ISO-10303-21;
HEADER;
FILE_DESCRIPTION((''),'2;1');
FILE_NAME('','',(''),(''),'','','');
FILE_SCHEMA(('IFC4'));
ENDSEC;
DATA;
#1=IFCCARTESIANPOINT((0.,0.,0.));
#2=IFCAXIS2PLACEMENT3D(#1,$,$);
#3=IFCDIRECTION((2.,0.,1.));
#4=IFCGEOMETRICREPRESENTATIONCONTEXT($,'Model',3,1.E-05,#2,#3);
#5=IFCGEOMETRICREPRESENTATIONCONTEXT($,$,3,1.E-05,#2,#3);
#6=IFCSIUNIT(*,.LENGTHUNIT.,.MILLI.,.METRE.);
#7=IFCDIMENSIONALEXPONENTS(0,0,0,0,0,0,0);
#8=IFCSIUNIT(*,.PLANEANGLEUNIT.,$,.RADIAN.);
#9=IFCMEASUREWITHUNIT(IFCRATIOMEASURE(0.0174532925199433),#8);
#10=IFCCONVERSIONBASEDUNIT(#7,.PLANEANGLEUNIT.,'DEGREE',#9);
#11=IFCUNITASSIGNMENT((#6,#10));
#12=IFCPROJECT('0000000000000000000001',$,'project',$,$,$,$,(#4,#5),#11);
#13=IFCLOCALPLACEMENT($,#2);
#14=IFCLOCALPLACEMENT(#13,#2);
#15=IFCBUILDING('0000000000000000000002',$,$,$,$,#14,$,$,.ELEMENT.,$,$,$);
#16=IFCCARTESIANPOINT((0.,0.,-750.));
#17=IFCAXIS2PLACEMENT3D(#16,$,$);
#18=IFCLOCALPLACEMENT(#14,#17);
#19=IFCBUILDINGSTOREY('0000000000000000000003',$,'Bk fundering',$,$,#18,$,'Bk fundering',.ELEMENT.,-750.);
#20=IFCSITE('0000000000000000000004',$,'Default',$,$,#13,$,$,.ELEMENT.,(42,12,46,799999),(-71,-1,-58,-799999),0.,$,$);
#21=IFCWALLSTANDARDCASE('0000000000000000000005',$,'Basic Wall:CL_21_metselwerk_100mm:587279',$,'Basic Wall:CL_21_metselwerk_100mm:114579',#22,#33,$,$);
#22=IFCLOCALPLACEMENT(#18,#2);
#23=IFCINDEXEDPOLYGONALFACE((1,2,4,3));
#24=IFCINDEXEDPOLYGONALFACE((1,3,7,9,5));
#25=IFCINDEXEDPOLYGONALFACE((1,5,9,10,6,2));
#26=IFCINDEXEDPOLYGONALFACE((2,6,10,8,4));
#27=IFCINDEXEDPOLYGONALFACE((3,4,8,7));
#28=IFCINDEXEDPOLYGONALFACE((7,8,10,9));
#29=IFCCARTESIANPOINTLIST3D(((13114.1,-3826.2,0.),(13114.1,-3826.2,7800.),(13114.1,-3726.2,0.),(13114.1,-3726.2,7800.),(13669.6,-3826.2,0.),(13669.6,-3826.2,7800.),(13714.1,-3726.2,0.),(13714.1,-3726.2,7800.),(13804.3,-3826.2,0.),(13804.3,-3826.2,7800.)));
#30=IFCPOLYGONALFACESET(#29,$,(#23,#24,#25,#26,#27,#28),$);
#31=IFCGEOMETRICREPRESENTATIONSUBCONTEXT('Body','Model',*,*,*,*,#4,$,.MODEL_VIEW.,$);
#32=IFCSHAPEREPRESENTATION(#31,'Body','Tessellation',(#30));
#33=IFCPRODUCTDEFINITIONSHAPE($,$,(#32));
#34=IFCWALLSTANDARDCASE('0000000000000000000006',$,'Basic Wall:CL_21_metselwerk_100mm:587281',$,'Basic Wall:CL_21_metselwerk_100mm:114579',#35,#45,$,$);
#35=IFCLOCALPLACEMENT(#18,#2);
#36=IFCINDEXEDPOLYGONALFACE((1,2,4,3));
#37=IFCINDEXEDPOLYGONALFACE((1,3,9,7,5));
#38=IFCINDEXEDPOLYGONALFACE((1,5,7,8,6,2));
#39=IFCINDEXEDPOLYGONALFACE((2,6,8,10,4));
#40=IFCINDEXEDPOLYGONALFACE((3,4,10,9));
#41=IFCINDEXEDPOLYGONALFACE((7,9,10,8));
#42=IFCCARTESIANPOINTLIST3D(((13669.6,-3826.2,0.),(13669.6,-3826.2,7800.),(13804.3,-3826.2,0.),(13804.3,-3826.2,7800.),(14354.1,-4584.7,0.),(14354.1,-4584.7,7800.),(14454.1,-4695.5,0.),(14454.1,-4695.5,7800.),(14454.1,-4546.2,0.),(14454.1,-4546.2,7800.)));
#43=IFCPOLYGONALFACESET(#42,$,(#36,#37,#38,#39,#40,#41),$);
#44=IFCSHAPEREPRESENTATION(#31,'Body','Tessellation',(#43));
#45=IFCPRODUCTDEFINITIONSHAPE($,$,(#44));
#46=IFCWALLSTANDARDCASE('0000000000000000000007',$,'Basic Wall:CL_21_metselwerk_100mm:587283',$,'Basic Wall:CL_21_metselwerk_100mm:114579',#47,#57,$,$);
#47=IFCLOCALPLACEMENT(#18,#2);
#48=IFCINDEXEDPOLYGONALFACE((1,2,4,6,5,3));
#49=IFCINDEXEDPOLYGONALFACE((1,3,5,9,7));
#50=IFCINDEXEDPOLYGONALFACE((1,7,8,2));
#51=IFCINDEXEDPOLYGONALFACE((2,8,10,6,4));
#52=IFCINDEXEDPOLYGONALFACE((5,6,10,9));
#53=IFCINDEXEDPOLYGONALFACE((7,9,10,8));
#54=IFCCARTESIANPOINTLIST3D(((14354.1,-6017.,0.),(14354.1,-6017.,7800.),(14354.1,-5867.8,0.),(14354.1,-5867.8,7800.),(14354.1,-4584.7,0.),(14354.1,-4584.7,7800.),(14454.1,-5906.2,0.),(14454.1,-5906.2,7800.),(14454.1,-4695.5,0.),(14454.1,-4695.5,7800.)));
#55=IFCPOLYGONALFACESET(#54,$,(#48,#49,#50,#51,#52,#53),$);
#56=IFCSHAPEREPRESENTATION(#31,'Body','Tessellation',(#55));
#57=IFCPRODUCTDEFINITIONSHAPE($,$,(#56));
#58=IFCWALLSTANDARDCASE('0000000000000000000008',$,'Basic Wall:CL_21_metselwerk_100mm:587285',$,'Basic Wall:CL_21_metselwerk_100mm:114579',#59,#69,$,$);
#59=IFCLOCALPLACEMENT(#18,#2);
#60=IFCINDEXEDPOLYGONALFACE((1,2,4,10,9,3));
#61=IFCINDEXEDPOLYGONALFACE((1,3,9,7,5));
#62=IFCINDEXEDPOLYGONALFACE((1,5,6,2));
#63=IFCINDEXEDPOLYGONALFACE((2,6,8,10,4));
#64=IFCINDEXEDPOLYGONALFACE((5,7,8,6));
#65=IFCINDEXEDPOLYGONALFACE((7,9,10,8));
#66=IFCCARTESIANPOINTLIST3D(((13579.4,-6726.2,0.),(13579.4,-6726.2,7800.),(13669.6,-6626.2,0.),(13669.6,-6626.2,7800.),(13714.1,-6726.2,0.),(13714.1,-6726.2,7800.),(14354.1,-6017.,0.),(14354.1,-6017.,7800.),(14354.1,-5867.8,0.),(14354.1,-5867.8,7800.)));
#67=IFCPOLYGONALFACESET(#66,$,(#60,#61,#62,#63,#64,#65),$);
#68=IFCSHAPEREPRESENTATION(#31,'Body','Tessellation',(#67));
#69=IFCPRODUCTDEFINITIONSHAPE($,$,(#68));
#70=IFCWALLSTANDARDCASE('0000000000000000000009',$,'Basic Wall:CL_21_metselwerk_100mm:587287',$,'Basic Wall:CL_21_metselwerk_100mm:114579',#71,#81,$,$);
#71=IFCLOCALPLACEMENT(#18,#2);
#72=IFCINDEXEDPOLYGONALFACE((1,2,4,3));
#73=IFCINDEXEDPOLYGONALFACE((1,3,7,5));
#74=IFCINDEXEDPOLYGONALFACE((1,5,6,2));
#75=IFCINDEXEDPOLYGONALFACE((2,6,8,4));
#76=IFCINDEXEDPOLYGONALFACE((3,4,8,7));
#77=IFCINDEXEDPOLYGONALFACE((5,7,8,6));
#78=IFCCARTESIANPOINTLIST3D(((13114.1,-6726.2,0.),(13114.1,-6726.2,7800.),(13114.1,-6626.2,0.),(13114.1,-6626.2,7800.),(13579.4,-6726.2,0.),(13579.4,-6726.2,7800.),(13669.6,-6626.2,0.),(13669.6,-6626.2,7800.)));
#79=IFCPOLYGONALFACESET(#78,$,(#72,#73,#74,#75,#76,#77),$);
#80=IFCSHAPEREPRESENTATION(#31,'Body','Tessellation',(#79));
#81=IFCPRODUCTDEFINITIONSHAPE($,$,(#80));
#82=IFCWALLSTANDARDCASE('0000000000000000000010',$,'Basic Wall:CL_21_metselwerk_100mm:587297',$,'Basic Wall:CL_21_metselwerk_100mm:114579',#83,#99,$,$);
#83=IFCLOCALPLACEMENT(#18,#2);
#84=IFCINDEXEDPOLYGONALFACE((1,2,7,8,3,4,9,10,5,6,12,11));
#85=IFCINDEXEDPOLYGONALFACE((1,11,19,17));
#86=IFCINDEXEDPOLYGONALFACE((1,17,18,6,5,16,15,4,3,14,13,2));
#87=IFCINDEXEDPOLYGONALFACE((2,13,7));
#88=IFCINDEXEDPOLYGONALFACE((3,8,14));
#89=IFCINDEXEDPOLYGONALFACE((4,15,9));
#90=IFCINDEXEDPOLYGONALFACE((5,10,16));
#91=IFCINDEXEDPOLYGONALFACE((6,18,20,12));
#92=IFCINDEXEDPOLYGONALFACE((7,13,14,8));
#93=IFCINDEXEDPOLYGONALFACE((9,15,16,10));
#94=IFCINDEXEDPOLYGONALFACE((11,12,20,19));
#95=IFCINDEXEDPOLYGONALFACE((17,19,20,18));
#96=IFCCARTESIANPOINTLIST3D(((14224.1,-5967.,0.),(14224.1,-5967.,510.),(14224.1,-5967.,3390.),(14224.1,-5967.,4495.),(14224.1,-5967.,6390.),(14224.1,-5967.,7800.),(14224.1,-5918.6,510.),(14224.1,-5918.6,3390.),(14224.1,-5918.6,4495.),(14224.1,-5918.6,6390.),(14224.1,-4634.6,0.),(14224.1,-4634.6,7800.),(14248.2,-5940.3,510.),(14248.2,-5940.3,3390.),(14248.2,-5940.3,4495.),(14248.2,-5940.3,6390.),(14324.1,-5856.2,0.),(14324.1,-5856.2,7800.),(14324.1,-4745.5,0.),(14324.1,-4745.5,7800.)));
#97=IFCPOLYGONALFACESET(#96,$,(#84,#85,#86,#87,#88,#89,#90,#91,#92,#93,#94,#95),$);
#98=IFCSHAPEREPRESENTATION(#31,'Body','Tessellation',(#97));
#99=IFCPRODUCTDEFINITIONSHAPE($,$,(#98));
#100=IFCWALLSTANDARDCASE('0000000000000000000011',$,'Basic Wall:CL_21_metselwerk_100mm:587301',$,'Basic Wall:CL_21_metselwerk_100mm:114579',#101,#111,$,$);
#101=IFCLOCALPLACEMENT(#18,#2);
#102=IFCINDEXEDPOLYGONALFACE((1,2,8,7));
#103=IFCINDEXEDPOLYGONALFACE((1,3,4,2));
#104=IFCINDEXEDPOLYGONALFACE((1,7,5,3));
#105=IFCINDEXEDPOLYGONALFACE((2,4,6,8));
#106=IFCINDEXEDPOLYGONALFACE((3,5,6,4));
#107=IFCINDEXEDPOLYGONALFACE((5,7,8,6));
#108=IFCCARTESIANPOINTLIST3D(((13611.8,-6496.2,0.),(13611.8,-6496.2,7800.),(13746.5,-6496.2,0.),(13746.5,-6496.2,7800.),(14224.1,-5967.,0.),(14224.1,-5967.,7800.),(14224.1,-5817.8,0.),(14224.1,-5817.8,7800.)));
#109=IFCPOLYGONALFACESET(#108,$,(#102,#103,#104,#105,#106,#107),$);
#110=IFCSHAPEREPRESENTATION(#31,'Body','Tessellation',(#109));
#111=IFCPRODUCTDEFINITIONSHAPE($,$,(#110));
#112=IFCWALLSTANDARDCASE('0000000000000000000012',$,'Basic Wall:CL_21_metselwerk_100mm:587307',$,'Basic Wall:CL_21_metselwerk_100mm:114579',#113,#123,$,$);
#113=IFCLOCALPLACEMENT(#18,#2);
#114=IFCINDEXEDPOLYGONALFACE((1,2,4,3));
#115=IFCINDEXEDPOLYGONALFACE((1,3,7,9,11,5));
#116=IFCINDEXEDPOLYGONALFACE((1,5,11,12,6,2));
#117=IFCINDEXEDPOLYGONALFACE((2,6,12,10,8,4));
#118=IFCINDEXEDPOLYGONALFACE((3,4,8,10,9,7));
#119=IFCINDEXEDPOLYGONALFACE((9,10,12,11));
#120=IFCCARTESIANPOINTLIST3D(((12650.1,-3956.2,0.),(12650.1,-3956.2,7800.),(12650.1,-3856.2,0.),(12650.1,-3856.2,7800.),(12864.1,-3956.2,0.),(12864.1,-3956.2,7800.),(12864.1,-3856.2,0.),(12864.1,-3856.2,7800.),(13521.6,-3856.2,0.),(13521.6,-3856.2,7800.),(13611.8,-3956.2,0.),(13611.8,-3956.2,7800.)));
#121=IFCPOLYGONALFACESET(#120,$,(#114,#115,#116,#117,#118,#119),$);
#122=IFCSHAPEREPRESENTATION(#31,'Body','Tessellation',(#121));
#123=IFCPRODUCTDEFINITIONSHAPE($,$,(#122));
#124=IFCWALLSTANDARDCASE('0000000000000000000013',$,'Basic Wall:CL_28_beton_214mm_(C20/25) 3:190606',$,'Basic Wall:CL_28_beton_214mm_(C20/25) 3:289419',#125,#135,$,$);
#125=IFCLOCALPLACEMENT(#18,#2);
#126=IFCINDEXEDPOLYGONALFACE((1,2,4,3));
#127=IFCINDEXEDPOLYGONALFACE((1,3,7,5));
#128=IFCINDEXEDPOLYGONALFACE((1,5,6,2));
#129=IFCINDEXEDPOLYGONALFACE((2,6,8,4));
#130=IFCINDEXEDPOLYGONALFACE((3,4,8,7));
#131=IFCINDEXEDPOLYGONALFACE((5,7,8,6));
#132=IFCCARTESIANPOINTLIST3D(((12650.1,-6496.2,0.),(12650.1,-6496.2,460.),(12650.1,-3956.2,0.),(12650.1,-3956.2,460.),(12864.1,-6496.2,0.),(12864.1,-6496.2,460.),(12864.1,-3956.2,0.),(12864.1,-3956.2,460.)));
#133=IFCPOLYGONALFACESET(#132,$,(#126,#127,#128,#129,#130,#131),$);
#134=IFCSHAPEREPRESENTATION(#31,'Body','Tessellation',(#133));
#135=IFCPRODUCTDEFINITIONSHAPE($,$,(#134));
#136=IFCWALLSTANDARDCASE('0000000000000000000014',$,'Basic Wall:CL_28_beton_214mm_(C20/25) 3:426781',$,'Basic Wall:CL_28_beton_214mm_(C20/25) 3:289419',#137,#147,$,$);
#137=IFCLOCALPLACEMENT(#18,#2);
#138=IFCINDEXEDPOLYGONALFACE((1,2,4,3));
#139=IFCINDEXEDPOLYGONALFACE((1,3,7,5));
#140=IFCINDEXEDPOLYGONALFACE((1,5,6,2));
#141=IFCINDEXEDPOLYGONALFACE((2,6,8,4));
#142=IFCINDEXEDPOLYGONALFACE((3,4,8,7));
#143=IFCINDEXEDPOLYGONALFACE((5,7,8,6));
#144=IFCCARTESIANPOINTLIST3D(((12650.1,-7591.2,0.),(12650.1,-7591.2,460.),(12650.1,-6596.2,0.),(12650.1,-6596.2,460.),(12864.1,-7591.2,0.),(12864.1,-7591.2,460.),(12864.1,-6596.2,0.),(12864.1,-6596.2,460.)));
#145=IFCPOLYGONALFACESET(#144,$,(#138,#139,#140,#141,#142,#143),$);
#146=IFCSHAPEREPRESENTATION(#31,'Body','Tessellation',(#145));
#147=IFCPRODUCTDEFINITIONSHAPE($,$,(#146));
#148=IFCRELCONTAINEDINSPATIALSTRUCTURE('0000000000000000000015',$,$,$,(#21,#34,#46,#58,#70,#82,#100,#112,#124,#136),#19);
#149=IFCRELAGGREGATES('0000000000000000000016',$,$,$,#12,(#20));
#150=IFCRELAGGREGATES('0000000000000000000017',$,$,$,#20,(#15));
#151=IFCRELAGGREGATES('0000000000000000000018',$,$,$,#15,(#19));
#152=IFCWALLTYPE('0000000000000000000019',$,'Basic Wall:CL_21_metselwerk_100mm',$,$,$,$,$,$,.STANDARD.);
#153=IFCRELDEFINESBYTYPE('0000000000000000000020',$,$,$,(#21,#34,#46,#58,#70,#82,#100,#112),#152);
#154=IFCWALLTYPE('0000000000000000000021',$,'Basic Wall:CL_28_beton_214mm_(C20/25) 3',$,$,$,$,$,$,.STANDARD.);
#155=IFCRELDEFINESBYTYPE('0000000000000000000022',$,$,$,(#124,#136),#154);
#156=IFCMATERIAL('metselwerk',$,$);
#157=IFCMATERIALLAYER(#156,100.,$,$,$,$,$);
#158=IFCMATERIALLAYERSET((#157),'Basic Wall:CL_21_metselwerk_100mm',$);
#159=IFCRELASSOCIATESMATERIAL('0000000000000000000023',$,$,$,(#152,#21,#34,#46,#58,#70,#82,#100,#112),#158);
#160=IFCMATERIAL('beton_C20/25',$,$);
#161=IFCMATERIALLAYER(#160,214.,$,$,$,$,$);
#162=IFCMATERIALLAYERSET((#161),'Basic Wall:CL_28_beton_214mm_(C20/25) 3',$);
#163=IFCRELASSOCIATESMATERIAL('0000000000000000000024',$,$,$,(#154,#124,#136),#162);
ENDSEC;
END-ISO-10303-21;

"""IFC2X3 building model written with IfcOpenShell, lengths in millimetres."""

from ifc_helpers import new_model, entity, si_unit, converted_unit, direction, frame, frame_2d, origin, origin_2d_with_axis, place, context, subcontext, project, spatial, polyline, rectangle, outline, extrude, clip, bounded_halfspace, material, layer, layer_set, layer_usage, type_object, element, save


model = new_model("IFC2X3")

# Units and contexts
model_context = context("Model", 3, precision=1e-05, world=origin(), true_north=direction((2.0, 0.0, 1.0)))
context_of_model = context(None, 3, precision=1e-05, world=origin(), true_north=direction((2.0, 0.0, 1.0)))
body_context = subcontext(model_context, "Body", "Model", "MODEL_VIEW")
ifc_project = project(units=[si_unit("LENGTHUNIT", "METRE", prefix="MILLI"), converted_unit("PLANEANGLEUNIT", "DEGREE", entity("IfcRatioMeasure", 0.0174532925199433), si_unit("PLANEANGLEUNIT", "RADIAN"), dimensions=[0, 0, 0, 0, 0, 0, 0])], contexts=[model_context, context_of_model])

# Site, building, storey
site_placement = place(None, origin())
site = spatial("IfcSite", under=ifc_project, at=site_placement, Name="Default", CompositionType="ELEMENT", RefLatitude=(42, 12, 46, 799999), RefLongitude=(-71, -1, -58, -799999), RefElevation=0.0)
building_placement = place(site_placement, origin())
building = spatial("IfcBuilding", under=site, at=building_placement, CompositionType="ELEMENT")
storey_placement = place(building_placement, frame((0.0, 0.0, -750.0)))
storey = spatial("IfcBuildingStorey", under=building, at=storey_placement, Name="Bk fundering", LongName="Bk fundering", CompositionType="ELEMENT", Elevation=-750.0)

# Walls
ifc_material_1 = material(Name="metselwerk")
ifc_layer_1 = layer(ifc_material_1, 100.0)
ifc_layer_set_1 = layer_set([ifc_layer_1], Name="Basic Wall:CL_21_metselwerk_100mm")
wall_type_1 = type_object("IfcWallType", Name="Basic Wall:CL_21_metselwerk_100mm", PredefinedType="STANDARD", material=ifc_layer_set_1)
ifc_layer_usage_1 = layer_usage(ifc_layer_set_1, "AXIS2", "POSITIVE", -50.0)
wall_1_placement = place(storey_placement, frame((13114.1, -3776.2, 0.0)))
element("IfcWallStandardCase", 1, at=wall_1_placement, inside=storey, type_object=wall_type_1, material=ifc_layer_usage_1, Name="Basic Wall:CL_21_metselwerk_100mm:587279", ObjectType="Basic Wall:CL_21_metselwerk_100mm:114579", context=body_context, shape_type="SweptSolid", body=[
    extrude(outline(polyline([(690.2, -50.0), (600.0, 50.0), (0.0, 50.0), (0.0, -50.0), (555.5, -50.0), (690.2, -50.0)])), origin(), (0.0, 0.0, 1.0), 7800.0),
])
ifc_layer_usage_2 = layer_usage(ifc_layer_set_1, "AXIS2", "POSITIVE", -50.0)
wall_2_placement = place(storey_placement, frame((13706.7, -3792.7, 0.0), z_axis=(0.0, 0.0, 1.0), x_axis=(0.669965, -0.742393, 0.0)))
element("IfcWallStandardCase", 2, at=wall_2_placement, inside=storey, type_object=wall_type_1, material=ifc_layer_usage_2, Name="Basic Wall:CL_21_metselwerk_100mm:587281", ObjectType="Basic Wall:CL_21_metselwerk_100mm:114579", context=body_context, shape_type="SweptSolid", body=[
    extrude(outline(polyline([(1170.9, -50.0), (1060.1, 50.0), (90.2, 50.0), (0.0, -50.0), (1021.6, -50.0), (1170.9, -50.0)])), origin(), (0.0, 0.0, 1.0), 7800.0),
])
ifc_layer_usage_3 = layer_usage(ifc_layer_set_1, "AXIS2", "POSITIVE", -50.0)
wall_3_placement = place(storey_placement, frame((14404.1, -4584.7, 0.0), z_axis=(0.0, 0.0, 1.0), x_axis=(0.0, -1.0, 0.0)))
element("IfcWallStandardCase", 3, at=wall_3_placement, inside=storey, type_object=wall_type_1, material=ifc_layer_usage_3, Name="Basic Wall:CL_21_metselwerk_100mm:587283", ObjectType="Basic Wall:CL_21_metselwerk_100mm:114579", context=body_context, shape_type="SweptSolid", body=[
    extrude(outline(polyline([(1432.4, -50.0), (1321.5, 50.0), (110.8, 50.0), (0.0, -50.0), (1283.1, -50.0), (1432.4, -50.0)])), origin(), (0.0, 0.0, 1.0), 7800.0),
])
ifc_layer_usage_4 = layer_usage(ifc_layer_set_1, "AXIS2", "POSITIVE", -50.0)
wall_4_placement = place(storey_placement, frame((14391.2, -5901.2, 0.0), z_axis=(0.0, 0.0, 1.0), x_axis=(-0.669965, -0.742393, 0.0)))
element("IfcWallStandardCase", 4, at=wall_4_placement, inside=storey, type_object=wall_type_1, material=ifc_layer_usage_4, Name="Basic Wall:CL_21_metselwerk_100mm:587285", ObjectType="Basic Wall:CL_21_metselwerk_100mm:114579", context=body_context, shape_type="SweptSolid", body=[
    extrude(outline(polyline([(1156.3, -50.0), (1066.1, 50.0), (110.8, 50.0), (0.0, -50.0), (1021.6, -50.0), (1156.3, -50.0)])), origin(), (0.0, 0.0, 1.0), 7800.0),
])
ifc_layer_usage_5 = layer_usage(ifc_layer_set_1, "AXIS2", "NEGATIVE", 50.0)
wall_5_placement = place(storey_placement, frame((13669.6, -6676.2, 0.0), z_axis=(0.0, 0.0, 1.0), x_axis=(-1.0, 0.0, 0.0)))
element("IfcWallStandardCase", 5, at=wall_5_placement, inside=storey, type_object=wall_type_1, material=ifc_layer_usage_5, Name="Basic Wall:CL_21_metselwerk_100mm:587287", ObjectType="Basic Wall:CL_21_metselwerk_100mm:114579", context=body_context, shape_type="SweptSolid", body=[
    extrude(outline(polyline([(555.5, -50.0), (555.5, 50.0), (90.2, 50.0), (0.0, -50.0), (555.5, -50.0)])), origin(), (0.0, 0.0, 1.0), 7800.0),
])

# Wall, openings
ifc_layer_usage_6 = layer_usage(ifc_layer_set_1, "AXIS2", "POSITIVE", -50.0)
wall_6_placement = place(storey_placement, frame((14274.1, -4634.6, 0.0), z_axis=(0.0, 0.0, 1.0), x_axis=(0.0, -1.0, 0.0)))
wall_6 = element("IfcWallStandardCase", 6, at=wall_6_placement, inside=storey, type_object=wall_type_1, material=ifc_layer_usage_6, Name="Basic Wall:CL_21_metselwerk_100mm:587297", ObjectType="Basic Wall:CL_21_metselwerk_100mm:114579", context=body_context, shape_type="SweptSolid", body=[
    extrude(outline(polyline([(1332.4, -50.0), (1221.6, 50.0), (110.8, 50.0), (0.0, -50.0), (1183.1, -50.0), (1332.4, -50.0)])), origin(), (0.0, 0.0, 1.0), 7800.0),
])
opening_1_placement = place(wall_6_placement, origin())
element("IfcOpeningElement", 7, at=opening_1_placement, cuts=wall_6, ObjectType="Recess", context=body_context, shape_type="SweptSolid", body=[
    extrude(rectangle(XDim=100.0, YDim=778.0, at=origin_2d_with_axis()), frame((1561.0, -323.6, 510.0), z_axis=(0.0, 0.0, 1.0), x_axis=(-0.669965, -0.742393, 0.0)), (0.0, 0.0, 1.0), 2880.0),
])
opening_2_placement = place(wall_6_placement, origin())
element("IfcOpeningElement", 8, at=opening_2_placement, cuts=wall_6, ObjectType="Recess", context=body_context, shape_type="SweptSolid", body=[
    extrude(rectangle(XDim=100.0, YDim=778.0, at=origin_2d_with_axis()), frame((1561.0, -323.6, 4495.0), z_axis=(0.0, 0.0, 1.0), x_axis=(-0.669965, -0.742393, 0.0)), (0.0, 0.0, 1.0), 1895.0),
])

# Wall
ifc_layer_usage_7 = layer_usage(ifc_layer_set_1, "AXIS2", "POSITIVE", -50.0)
wall_7_placement = place(storey_placement, frame((14261.2, -5851.3, 0.0), z_axis=(0.0, 0.0, 1.0), x_axis=(-0.669965, -0.742393, 0.0)))
element("IfcWallStandardCase", 9, at=wall_7_placement, inside=storey, type_object=wall_type_1, material=ifc_layer_usage_7, Name="Basic Wall:CL_21_metselwerk_100mm:587301", ObjectType="Basic Wall:CL_21_metselwerk_100mm:114579", context=body_context, shape_type="SweptSolid", body=[
    extrude(outline(polyline([(913.9, -50.0), (823.6, 50.0), (110.8, 50.0), (0.0, -50.0), (913.9, -50.0)])), origin(), (0.0, 0.0, 1.0), 7800.0),
])

# Walls
ifc_layer_usage_8 = layer_usage(ifc_layer_set_1, "AXIS2", "POSITIVE", -50.0)
wall_8_placement = place(storey_placement, frame((12650.1, -3906.2, 0.0)))
element("IfcWallStandardCase", 10, at=wall_8_placement, inside=storey, type_object=wall_type_1, material=ifc_layer_usage_8, Name="Basic Wall:CL_21_metselwerk_100mm:587307", ObjectType="Basic Wall:CL_21_metselwerk_100mm:114579", context=body_context, shape_type="SweptSolid", body=[
    extrude(outline(polyline([(961.8, -50.0), (871.5, 50.0), (214.0, 50.0), (0.0, 50.0), (0.0, -50.0), (214.0, -50.0), (961.8, -50.0)])), origin(), (0.0, 0.0, 1.0), 7800.0),
])
ifc_material_2 = material(Name="beton_C20/25")
ifc_layer_2 = layer(ifc_material_2, 214.0)
ifc_layer_set_2 = layer_set([ifc_layer_2], Name="Basic Wall:CL_28_beton_214mm_(C20/25) 3")
ifc_layer_usage_9 = layer_usage(ifc_layer_set_2, "AXIS2", "NEGATIVE", 107.0)
wall_type_2 = type_object("IfcWallType", Name="Basic Wall:CL_28_beton_214mm_(C20/25) 3", PredefinedType="STANDARD", material=ifc_layer_set_2)
wall_9_placement = place(storey_placement, frame((12757.1, -6496.2, 0.0), z_axis=(0.0, 0.0, 1.0), x_axis=(0.0, 1.0, 0.0)))
element("IfcWallStandardCase", 11, at=wall_9_placement, inside=storey, type_object=wall_type_2, material=ifc_layer_usage_9, Name="Basic Wall:CL_28_beton_214mm_(C20/25) 3:190606", ObjectType="Basic Wall:CL_28_beton_214mm_(C20/25) 3:289419", context=body_context, shape_type="Clipping", body=[
    clip(extrude(rectangle(XDim=2540.0, YDim=214.0, at=frame_2d((1270.0, 0.0), x_axis=(-1.0, 0.0))), origin(), (0.0, 0.0, 1.0), 460.0), bounded_halfspace(frame((0.0, -107.0, 460.0), z_axis=(0.0, 0.0, -1.0), x_axis=(-1.0, 0.0, 0.0)), True, frame((0.0, -107.0, 460.0)), polyline([(0.0, 0.0), (2540.0, 0.0), (2540.0, 214.0), (0.0, 214.0), (0.0, 0.0)]))),
])
ifc_layer_usage_10 = layer_usage(ifc_layer_set_2, "AXIS2", "NEGATIVE", 107.0)
wall_10_placement = place(storey_placement, frame((12757.1, -7591.2, 0.0), z_axis=(0.0, 0.0, 1.0), x_axis=(0.0, 1.0, 0.0)))
element("IfcWallStandardCase", 12, at=wall_10_placement, inside=storey, type_object=wall_type_2, material=ifc_layer_usage_10, Name="Basic Wall:CL_28_beton_214mm_(C20/25) 3:426781", ObjectType="Basic Wall:CL_28_beton_214mm_(C20/25) 3:289419", context=body_context, shape_type="Clipping", body=[
    clip(extrude(rectangle(XDim=995.0, YDim=214.0, at=frame_2d((497.5, 0.0), x_axis=(-1.0, 0.0))), origin(), (0.0, 0.0, 1.0), 460.0), bounded_halfspace(frame((0.0, -107.0, 460.0), z_axis=(0.0, 0.0, -1.0), x_axis=(-1.0, 0.0, 0.0)), True, frame((0.0, -107.0, 460.0)), polyline([(0.0, 0.0), (995.0, 0.0), (995.0, 214.0), (0.0, 214.0), (0.0, 0.0)]))),
])

save(model, "model.ifc")
